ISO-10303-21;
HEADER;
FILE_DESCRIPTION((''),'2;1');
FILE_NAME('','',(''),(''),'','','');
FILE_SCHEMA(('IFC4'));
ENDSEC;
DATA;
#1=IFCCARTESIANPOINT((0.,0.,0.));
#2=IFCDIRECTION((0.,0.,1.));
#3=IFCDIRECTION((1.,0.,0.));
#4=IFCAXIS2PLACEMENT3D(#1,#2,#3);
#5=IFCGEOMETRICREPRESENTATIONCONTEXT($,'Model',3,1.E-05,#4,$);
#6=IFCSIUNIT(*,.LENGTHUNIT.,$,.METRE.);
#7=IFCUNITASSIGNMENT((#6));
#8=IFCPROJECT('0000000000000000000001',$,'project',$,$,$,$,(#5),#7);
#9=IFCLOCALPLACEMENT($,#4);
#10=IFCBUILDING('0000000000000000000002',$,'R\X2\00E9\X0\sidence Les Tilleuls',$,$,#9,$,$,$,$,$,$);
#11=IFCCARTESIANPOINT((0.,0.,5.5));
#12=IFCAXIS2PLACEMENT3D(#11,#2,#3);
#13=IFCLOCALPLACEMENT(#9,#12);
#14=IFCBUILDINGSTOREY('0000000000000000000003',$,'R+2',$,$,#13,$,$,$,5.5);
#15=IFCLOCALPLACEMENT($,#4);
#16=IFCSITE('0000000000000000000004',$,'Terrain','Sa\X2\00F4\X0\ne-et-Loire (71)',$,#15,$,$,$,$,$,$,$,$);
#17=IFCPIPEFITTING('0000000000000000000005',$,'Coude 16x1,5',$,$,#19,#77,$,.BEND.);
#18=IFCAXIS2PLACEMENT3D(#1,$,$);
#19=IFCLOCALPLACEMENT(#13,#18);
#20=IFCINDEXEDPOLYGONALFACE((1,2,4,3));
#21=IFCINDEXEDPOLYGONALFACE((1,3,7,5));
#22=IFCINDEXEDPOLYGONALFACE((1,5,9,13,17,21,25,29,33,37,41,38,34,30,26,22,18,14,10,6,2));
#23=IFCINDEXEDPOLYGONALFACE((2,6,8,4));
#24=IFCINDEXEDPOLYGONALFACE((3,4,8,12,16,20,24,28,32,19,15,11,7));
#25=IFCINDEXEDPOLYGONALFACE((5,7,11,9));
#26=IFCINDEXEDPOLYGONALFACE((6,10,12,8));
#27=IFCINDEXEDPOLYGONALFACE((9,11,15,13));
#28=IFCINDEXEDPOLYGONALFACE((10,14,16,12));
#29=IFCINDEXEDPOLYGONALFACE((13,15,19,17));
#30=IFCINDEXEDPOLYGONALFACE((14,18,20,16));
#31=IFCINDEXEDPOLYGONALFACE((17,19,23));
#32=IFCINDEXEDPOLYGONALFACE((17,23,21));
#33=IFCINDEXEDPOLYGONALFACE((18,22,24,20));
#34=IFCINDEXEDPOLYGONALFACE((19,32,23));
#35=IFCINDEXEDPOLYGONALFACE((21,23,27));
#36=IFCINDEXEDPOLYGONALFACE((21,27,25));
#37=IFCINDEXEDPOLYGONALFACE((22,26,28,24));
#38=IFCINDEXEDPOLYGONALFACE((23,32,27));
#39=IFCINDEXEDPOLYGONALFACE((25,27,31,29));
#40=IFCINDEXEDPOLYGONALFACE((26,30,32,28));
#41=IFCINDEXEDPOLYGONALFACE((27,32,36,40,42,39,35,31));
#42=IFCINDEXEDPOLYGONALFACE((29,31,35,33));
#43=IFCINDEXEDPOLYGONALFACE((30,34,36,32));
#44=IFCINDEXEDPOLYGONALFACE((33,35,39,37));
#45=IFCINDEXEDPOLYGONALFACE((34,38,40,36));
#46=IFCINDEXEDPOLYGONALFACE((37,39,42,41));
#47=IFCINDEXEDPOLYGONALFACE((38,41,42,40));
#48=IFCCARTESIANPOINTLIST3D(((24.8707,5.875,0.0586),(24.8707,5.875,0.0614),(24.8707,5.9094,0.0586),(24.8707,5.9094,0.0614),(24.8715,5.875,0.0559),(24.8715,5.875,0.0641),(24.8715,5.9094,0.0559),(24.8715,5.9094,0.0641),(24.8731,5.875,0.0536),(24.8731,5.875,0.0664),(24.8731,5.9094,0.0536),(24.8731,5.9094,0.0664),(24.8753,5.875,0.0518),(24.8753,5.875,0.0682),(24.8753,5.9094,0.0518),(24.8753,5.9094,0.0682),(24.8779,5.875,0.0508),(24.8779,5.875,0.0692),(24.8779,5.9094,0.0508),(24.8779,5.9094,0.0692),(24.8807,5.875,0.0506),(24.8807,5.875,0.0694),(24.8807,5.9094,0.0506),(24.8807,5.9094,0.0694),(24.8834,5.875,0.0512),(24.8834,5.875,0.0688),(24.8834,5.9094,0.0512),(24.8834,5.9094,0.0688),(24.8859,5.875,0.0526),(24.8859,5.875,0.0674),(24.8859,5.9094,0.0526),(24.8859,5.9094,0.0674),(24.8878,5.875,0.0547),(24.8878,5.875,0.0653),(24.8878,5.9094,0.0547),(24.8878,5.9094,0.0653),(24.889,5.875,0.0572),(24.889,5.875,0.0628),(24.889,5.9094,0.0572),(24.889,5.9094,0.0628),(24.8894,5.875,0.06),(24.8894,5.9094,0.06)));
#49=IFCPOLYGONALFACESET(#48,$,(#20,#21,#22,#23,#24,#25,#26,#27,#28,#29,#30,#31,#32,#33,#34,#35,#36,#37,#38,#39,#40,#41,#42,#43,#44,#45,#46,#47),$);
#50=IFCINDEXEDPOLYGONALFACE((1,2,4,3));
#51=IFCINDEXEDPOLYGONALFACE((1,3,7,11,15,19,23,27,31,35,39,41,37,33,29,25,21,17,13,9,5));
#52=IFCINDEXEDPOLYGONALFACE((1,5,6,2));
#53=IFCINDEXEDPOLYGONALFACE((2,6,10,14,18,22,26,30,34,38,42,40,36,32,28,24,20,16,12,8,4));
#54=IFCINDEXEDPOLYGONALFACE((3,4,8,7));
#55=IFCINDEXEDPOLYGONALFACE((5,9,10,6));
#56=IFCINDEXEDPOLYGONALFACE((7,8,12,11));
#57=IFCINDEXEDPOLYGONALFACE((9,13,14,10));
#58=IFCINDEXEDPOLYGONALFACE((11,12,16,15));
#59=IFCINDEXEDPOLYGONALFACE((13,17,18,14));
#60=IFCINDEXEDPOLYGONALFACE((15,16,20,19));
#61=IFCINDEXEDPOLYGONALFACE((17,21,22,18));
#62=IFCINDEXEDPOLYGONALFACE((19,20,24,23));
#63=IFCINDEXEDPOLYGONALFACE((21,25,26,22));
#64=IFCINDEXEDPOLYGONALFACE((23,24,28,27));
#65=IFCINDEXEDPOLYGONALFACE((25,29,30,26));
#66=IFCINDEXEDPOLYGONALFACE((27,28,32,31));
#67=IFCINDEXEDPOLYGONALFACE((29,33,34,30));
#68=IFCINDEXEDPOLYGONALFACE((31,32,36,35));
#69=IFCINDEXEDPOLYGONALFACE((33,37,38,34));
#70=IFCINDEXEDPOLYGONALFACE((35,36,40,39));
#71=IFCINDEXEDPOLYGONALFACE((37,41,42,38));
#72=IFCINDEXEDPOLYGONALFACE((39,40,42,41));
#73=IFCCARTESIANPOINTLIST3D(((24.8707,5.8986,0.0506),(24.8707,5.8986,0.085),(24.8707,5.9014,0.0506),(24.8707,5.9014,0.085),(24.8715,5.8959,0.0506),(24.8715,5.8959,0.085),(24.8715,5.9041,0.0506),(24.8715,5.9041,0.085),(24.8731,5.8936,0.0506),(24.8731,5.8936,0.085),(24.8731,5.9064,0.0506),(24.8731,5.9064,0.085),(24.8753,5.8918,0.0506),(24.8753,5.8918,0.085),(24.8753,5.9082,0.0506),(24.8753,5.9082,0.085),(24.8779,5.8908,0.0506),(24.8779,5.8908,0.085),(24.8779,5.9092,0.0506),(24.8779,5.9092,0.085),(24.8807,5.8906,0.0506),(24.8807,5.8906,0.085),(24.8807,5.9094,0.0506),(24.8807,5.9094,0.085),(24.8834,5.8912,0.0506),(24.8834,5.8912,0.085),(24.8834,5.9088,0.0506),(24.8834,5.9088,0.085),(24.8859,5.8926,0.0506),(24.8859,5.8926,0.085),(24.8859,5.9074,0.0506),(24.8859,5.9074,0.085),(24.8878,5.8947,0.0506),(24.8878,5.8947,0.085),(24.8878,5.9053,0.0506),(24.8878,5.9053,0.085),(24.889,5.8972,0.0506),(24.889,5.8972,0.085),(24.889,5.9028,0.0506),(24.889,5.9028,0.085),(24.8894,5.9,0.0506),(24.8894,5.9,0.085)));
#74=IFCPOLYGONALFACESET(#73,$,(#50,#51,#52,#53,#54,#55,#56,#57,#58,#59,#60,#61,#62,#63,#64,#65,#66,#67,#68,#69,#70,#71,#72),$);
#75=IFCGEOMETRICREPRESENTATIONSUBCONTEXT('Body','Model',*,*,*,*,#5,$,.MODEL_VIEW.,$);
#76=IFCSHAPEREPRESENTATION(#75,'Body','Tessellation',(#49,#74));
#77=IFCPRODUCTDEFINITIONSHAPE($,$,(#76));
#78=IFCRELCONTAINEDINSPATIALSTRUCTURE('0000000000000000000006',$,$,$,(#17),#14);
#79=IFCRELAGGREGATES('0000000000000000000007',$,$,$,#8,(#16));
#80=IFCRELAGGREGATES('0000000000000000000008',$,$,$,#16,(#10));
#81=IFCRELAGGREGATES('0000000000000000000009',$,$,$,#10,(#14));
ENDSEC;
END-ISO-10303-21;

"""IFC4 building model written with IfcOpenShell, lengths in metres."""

from ifc_helpers import new_model, si_unit, frame, origin_with_axes, place, context, subcontext, project, spatial, circle, extrude, element, save


model = new_model("IFC4")

# Units and contexts
model_context = context("Model", 3, precision=1e-05, world=origin_with_axes())
body_context = subcontext(model_context, "Body", "Model", "MODEL_VIEW")
ifc_project = project(units=[si_unit("LENGTHUNIT", "METRE")], contexts=[model_context])

# Site, building, storey
site_placement = place(None, origin_with_axes())
site = spatial("IfcSite", under=ifc_project, at=site_placement, Name="Terrain", Description="Saône-et-Loire (71)")
building_placement = place(None, origin_with_axes())
building = spatial("IfcBuilding", under=site, at=building_placement, Name="Résidence Les Tilleuls")
storey_placement = place(building_placement, frame((0.0, 0.0, 5.5), z_axis=(0.0, 0.0, 1.0), x_axis=(1.0, 0.0, 0.0)))
storey = spatial("IfcBuildingStorey", under=building, at=storey_placement, Name="R+2", Elevation=5.5)

# Pipe fitting
pipe_fitting_1_placement = place(storey_placement, frame((24.88, 5.9, 0.06), z_axis=(0.0, 0.0, 1.0), x_axis=(1.0, 0.0, 0.0)))
element("IfcPipeFitting", 1, at=pipe_fitting_1_placement, inside=storey, Name="Coude 16x1,5", PredefinedType="BEND", context=body_context, shape_type="SweptSolid", body=[
    extrude(circle(Radius=0.0094), frame((0.0, 0.0094, 0.0), z_axis=(0.0, -1.0, 0.0), x_axis=(1.0, 0.0, 0.0)), (0.0, 0.0, 1.0), 0.0344),
    extrude(circle(Radius=0.0094), frame((0.0, 0.0, -0.0094), z_axis=(0.0, 0.0, 1.0), x_axis=(1.0, 0.0, 0.0)), (0.0, 0.0, 1.0), 0.0344),
])

save(model, "model.ifc")
